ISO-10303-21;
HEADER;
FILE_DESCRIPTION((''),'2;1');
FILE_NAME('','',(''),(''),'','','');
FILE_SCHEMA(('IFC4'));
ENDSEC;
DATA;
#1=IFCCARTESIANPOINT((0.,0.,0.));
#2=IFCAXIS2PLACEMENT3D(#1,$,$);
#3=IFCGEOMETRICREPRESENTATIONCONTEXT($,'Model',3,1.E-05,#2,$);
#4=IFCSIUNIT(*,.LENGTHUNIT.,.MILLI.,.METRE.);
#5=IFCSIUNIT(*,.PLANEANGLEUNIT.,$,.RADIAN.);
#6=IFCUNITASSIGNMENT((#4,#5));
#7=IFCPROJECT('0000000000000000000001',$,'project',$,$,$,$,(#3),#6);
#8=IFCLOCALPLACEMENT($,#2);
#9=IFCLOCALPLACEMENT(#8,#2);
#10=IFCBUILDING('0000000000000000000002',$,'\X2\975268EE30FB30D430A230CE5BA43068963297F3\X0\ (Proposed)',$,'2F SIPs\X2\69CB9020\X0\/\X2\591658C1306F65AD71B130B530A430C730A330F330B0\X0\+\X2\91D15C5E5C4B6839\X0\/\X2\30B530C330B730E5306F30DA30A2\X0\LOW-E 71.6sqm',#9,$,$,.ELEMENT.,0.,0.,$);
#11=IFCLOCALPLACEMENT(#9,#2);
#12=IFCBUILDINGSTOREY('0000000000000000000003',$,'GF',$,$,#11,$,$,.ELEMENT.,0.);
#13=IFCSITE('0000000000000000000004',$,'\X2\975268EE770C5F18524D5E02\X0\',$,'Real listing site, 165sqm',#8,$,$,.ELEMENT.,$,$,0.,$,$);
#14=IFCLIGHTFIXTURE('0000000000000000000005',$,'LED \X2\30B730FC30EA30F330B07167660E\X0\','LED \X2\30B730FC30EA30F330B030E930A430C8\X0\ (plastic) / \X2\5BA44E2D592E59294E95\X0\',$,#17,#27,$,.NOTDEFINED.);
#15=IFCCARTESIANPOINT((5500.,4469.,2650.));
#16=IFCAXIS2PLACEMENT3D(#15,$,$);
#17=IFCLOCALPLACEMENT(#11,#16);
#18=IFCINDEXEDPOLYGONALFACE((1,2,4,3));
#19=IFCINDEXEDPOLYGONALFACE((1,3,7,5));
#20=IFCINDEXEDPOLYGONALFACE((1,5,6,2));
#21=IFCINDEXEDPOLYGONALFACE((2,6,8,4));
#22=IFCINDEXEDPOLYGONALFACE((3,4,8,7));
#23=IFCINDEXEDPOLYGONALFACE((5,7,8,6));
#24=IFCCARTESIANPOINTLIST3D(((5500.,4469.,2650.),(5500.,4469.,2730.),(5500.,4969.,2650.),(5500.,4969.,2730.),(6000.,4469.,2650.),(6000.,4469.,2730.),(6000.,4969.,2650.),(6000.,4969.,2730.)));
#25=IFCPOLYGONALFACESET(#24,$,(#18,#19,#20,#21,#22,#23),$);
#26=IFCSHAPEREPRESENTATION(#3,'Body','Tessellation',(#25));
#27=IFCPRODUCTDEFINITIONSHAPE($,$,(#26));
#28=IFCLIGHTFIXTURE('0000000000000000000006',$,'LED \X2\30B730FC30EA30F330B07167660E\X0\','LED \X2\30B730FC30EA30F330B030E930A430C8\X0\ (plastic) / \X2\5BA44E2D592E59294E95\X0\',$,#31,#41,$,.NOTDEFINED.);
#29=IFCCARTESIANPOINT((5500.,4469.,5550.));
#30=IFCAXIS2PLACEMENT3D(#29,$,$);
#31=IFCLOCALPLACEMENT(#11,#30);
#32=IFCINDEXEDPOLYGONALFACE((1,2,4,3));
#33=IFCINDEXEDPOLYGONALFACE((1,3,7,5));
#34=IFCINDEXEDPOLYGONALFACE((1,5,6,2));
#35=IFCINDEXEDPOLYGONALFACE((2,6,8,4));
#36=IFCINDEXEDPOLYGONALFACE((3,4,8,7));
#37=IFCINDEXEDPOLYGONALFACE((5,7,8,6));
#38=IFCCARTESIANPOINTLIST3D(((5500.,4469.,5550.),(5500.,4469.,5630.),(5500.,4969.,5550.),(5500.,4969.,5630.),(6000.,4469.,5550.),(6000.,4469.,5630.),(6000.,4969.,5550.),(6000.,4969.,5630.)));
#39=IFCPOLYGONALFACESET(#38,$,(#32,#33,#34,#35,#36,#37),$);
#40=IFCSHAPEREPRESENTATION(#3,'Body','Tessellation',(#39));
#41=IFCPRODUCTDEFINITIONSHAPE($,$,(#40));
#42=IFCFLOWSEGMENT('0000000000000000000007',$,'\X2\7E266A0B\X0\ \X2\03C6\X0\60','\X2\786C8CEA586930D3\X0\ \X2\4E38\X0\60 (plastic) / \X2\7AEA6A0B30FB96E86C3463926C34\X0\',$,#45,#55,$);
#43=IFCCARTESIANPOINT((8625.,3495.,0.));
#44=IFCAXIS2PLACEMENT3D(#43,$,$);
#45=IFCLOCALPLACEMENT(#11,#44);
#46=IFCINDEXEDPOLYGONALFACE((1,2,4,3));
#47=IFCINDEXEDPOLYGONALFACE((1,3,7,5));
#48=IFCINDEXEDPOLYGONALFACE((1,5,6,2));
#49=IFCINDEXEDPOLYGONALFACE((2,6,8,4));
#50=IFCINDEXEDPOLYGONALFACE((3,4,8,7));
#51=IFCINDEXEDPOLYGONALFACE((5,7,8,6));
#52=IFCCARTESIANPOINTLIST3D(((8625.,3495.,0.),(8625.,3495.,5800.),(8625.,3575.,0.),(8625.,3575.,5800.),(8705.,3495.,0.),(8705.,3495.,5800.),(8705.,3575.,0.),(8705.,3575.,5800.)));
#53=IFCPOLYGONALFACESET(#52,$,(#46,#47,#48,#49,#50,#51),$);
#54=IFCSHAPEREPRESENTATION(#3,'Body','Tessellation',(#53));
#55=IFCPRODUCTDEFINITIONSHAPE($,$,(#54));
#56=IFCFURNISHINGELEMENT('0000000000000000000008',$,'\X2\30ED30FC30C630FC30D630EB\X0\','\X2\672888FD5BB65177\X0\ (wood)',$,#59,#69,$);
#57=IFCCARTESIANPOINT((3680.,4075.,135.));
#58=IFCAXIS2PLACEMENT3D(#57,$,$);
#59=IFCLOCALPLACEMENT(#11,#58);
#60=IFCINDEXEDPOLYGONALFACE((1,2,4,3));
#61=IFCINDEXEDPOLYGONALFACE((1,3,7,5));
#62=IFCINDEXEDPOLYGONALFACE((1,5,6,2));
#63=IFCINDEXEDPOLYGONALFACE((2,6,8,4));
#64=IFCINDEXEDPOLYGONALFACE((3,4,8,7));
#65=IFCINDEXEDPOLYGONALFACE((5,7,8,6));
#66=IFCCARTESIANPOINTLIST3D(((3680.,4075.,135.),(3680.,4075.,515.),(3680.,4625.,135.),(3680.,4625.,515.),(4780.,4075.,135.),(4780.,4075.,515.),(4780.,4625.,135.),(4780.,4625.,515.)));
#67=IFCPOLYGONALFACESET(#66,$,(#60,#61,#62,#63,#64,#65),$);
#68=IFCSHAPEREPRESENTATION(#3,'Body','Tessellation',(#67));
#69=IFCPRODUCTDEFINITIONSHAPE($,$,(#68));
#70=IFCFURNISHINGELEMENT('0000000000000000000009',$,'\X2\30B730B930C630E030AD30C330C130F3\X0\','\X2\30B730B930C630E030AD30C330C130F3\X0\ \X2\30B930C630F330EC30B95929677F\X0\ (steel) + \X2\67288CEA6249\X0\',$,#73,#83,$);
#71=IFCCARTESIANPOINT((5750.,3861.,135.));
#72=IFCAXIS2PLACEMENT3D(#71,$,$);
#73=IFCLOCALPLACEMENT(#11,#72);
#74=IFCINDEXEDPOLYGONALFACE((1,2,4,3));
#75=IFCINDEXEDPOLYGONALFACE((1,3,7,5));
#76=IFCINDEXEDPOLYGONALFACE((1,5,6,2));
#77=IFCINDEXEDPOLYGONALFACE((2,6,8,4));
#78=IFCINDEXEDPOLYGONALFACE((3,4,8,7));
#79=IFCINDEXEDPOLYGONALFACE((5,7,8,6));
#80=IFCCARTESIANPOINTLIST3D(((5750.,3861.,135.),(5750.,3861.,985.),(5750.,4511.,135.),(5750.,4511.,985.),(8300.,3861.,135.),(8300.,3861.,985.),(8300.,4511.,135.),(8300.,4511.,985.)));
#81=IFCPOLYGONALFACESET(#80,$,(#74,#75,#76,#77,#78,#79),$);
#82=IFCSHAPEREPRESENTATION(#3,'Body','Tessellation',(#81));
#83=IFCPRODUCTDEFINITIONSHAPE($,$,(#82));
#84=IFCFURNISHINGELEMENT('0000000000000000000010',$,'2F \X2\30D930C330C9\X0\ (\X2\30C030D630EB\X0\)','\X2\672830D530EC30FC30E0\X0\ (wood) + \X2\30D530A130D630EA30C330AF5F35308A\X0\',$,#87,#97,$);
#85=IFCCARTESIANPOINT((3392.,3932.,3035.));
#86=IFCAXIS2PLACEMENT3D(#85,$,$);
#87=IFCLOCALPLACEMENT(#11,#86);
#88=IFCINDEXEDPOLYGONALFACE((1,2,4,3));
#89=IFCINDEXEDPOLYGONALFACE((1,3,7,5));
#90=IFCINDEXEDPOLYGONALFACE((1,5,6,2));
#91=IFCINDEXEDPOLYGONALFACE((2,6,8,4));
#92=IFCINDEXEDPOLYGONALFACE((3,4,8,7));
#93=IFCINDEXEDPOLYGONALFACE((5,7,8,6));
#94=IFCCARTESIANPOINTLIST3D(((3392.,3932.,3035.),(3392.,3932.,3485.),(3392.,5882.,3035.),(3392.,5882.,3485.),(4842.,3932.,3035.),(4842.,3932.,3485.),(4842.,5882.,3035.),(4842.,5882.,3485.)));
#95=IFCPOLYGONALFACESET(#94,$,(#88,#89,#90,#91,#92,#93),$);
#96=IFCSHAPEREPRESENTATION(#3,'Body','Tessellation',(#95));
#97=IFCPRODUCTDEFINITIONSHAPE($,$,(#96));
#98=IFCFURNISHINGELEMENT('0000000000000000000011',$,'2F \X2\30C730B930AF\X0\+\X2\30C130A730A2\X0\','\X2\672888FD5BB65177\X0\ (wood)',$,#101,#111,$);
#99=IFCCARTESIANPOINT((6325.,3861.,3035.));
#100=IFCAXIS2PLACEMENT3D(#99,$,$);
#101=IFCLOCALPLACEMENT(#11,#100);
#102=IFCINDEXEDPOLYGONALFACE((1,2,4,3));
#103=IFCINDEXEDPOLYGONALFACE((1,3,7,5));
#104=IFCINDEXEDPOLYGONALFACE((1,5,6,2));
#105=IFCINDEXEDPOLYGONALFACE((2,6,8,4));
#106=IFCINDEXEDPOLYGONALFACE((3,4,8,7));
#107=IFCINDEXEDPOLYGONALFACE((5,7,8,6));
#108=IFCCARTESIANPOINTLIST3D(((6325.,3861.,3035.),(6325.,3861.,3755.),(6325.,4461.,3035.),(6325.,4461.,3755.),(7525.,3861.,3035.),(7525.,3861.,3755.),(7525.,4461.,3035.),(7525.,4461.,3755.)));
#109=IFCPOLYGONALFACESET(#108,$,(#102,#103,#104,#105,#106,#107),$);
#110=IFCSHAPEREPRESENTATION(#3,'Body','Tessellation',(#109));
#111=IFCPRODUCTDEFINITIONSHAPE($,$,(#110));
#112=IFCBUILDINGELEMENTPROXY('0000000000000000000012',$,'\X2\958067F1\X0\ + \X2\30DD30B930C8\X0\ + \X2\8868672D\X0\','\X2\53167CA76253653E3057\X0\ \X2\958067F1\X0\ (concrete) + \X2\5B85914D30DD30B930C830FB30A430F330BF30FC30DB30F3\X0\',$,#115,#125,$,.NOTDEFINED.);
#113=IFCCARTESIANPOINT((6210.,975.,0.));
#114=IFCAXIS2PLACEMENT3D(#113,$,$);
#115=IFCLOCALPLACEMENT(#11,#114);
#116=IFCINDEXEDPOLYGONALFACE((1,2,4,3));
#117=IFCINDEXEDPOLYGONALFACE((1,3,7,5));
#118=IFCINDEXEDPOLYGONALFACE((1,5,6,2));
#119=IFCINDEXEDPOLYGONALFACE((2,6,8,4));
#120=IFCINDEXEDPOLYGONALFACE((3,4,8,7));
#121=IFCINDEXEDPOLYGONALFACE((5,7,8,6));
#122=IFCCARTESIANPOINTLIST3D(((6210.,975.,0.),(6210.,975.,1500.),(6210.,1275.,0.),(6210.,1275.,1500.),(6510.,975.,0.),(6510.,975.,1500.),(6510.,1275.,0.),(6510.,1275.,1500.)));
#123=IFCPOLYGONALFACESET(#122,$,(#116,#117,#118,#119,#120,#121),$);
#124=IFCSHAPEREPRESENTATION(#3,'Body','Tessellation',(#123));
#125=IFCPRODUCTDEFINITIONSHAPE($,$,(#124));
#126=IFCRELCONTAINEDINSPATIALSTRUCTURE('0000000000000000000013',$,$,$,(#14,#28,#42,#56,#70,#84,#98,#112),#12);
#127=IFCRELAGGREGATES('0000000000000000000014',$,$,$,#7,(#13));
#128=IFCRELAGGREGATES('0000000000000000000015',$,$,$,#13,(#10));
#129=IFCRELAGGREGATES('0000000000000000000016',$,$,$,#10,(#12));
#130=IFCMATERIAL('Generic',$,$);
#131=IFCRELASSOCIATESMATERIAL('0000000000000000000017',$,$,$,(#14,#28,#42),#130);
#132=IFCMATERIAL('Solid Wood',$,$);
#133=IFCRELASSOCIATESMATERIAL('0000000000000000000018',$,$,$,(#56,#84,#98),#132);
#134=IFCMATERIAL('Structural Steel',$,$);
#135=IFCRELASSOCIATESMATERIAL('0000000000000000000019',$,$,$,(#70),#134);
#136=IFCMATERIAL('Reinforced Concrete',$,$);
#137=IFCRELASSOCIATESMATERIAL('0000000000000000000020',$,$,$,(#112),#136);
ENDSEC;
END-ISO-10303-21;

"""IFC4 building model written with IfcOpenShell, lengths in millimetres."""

from ifc_helpers import new_model, si_unit, frame, frame_2d, origin, place, context, project, spatial, rectangle, extrude, material, element, save


model = new_model("IFC4")

# Units and contexts
model_context = context("Model", 3, precision=1e-05, world=origin())
ifc_project = project(units=[si_unit("LENGTHUNIT", "METRE", prefix="MILLI"), si_unit("PLANEANGLEUNIT", "RADIAN")], contexts=[model_context])

# Site, building, storey
site_placement = place(None, origin())
site = spatial("IfcSite", under=ifc_project, at=site_placement, Name="青森県弘前市", ObjectType="Real listing site, 165sqm", CompositionType="ELEMENT", RefElevation=0.0)
building_placement = place(site_placement, origin())
building = spatial("IfcBuilding", under=site, at=building_placement, Name="青森・ピアノ室と防音 (Proposed)", ObjectType="2F SIPs構造/外壁は断熱サイディング+金属屋根/サッシュはペアLOW-E 71.6sqm", CompositionType="ELEMENT", ElevationOfRefHeight=0.0, ElevationOfTerrain=0.0)
storey_placement = place(building_placement, origin())
storey = spatial("IfcBuildingStorey", under=building, at=storey_placement, Name="GF", CompositionType="ELEMENT", Elevation=0.0)

# Shared definitions
ifc_material_1 = material(Name="Solid Wood")

# Shared definitions
ifc_material_2 = material(Name="Reinforced Concrete")

# Shared definitions
ifc_material_3 = material(Name="Structural Steel")

# Shared definitions
ifc_material_4 = material(Name="Generic")

# Light fixtures
light_fixture_1_placement = place(storey_placement, frame((5500.0, 4469.0, 2650.0)))
element("IfcLightFixture", 1, at=light_fixture_1_placement, inside=storey, material=ifc_material_4, Name="LED シーリング照明", Description="LED シーリングライト (plastic) / 室中央天井", PredefinedType="NOTDEFINED", context=model_context, shape_type="SweptSolid", body=[
    extrude(rectangle(XDim=500.0, YDim=500.0, at=frame_2d((250.0, 250.0))), frame((5500.0, 4469.0, 2650.0)), (0.0, 0.0, 1.0), 80.0),
])
light_fixture_2_placement = place(storey_placement, frame((5500.0, 4469.0, 5550.0)))
element("IfcLightFixture", 2, at=light_fixture_2_placement, inside=storey, material=ifc_material_4, Name="LED シーリング照明", Description="LED シーリングライト (plastic) / 室中央天井", PredefinedType="NOTDEFINED", context=model_context, shape_type="SweptSolid", body=[
    extrude(rectangle(XDim=500.0, YDim=500.0, at=frame_2d((250.0, 250.0))), frame((5500.0, 4469.0, 5550.0)), (0.0, 0.0, 1.0), 80.0),
])

# Flow segment
flow_segment_placement = place(storey_placement, frame((8625.0, 3495.0, 0.0)))
element("IfcFlowSegment", 3, at=flow_segment_placement, inside=storey, material=ifc_material_4, Name="縦樋 φ60", Description="硬質塩ビ 丸60 (plastic) / 竪樋・雨水排水", context=model_context, shape_type="SweptSolid", body=[
    extrude(rectangle(XDim=80.0, YDim=80.0, at=frame_2d((40.0, 40.0))), frame((8625.0, 3495.0, 0.0)), (0.0, 0.0, 1.0), 5800.0),
])

# Furnishing elements
furnishing_1_placement = place(storey_placement, frame((3680.0, 4075.0, 135.0)))
element("IfcFurnishingElement", 4, at=furnishing_1_placement, inside=storey, material=ifc_material_1, Name="ローテーブル", Description="木製家具 (wood)", context=model_context, shape_type="SweptSolid", body=[
    extrude(rectangle(XDim=1100.0, YDim=550.0, at=frame_2d((550.0, 275.0))), frame((3680.0, 4075.0, 135.0)), (0.0, 0.0, 1.0), 380.0),
])
furnishing_2_placement = place(storey_placement, frame((5750.0, 3861.0, 135.0)))
element("IfcFurnishingElement", 5, at=furnishing_2_placement, inside=storey, material=ifc_material_3, Name="システムキッチン", Description="システムキッチン ステンレス天板 (steel) + 木質扉", context=model_context, shape_type="SweptSolid", body=[
    extrude(rectangle(XDim=2550.0, YDim=650.0, at=frame_2d((1275.0, 325.0))), frame((5750.0, 3861.0, 135.0)), (0.0, 0.0, 1.0), 850.0),
])
furnishing_3_placement = place(storey_placement, frame((3392.0, 3932.0, 3035.0)))
element("IfcFurnishingElement", 6, at=furnishing_3_placement, inside=storey, material=ifc_material_1, Name="2F ベッド (ダブル)", Description="木フレーム (wood) + ファブリック張り", context=model_context, shape_type="SweptSolid", body=[
    extrude(rectangle(XDim=1450.0, YDim=1950.0, at=frame_2d((725.0, 975.0))), frame((3392.0, 3932.0, 3035.0)), (0.0, 0.0, 1.0), 450.0),
])
furnishing_4_placement = place(storey_placement, frame((6325.0, 3861.0, 3035.0)))
element("IfcFurnishingElement", 7, at=furnishing_4_placement, inside=storey, material=ifc_material_1, Name="2F デスク+チェア", Description="木製家具 (wood)", context=model_context, shape_type="SweptSolid", body=[
    extrude(rectangle(XDim=1200.0, YDim=600.0, at=frame_2d((600.0, 300.0))), frame((6325.0, 3861.0, 3035.0)), (0.0, 0.0, 1.0), 720.0),
])

# Building element proxy
proxy_placement = place(storey_placement, frame((6210.0, 975.0, 0.0)))
element("IfcBuildingElementProxy", 8, at=proxy_placement, inside=storey, material=ifc_material_2, Name="門柱 + ポスト + 表札", Description="化粧打放し 門柱 (concrete) + 宅配ポスト・インターホン", PredefinedType="NOTDEFINED", context=model_context, shape_type="SweptSolid", body=[
    extrude(rectangle(XDim=300.0, YDim=300.0, at=frame_2d((150.0, 150.0))), frame((6210.0, 975.0, 0.0)), (0.0, 0.0, 1.0), 1500.0),
])

save(model, "model.ifc")
